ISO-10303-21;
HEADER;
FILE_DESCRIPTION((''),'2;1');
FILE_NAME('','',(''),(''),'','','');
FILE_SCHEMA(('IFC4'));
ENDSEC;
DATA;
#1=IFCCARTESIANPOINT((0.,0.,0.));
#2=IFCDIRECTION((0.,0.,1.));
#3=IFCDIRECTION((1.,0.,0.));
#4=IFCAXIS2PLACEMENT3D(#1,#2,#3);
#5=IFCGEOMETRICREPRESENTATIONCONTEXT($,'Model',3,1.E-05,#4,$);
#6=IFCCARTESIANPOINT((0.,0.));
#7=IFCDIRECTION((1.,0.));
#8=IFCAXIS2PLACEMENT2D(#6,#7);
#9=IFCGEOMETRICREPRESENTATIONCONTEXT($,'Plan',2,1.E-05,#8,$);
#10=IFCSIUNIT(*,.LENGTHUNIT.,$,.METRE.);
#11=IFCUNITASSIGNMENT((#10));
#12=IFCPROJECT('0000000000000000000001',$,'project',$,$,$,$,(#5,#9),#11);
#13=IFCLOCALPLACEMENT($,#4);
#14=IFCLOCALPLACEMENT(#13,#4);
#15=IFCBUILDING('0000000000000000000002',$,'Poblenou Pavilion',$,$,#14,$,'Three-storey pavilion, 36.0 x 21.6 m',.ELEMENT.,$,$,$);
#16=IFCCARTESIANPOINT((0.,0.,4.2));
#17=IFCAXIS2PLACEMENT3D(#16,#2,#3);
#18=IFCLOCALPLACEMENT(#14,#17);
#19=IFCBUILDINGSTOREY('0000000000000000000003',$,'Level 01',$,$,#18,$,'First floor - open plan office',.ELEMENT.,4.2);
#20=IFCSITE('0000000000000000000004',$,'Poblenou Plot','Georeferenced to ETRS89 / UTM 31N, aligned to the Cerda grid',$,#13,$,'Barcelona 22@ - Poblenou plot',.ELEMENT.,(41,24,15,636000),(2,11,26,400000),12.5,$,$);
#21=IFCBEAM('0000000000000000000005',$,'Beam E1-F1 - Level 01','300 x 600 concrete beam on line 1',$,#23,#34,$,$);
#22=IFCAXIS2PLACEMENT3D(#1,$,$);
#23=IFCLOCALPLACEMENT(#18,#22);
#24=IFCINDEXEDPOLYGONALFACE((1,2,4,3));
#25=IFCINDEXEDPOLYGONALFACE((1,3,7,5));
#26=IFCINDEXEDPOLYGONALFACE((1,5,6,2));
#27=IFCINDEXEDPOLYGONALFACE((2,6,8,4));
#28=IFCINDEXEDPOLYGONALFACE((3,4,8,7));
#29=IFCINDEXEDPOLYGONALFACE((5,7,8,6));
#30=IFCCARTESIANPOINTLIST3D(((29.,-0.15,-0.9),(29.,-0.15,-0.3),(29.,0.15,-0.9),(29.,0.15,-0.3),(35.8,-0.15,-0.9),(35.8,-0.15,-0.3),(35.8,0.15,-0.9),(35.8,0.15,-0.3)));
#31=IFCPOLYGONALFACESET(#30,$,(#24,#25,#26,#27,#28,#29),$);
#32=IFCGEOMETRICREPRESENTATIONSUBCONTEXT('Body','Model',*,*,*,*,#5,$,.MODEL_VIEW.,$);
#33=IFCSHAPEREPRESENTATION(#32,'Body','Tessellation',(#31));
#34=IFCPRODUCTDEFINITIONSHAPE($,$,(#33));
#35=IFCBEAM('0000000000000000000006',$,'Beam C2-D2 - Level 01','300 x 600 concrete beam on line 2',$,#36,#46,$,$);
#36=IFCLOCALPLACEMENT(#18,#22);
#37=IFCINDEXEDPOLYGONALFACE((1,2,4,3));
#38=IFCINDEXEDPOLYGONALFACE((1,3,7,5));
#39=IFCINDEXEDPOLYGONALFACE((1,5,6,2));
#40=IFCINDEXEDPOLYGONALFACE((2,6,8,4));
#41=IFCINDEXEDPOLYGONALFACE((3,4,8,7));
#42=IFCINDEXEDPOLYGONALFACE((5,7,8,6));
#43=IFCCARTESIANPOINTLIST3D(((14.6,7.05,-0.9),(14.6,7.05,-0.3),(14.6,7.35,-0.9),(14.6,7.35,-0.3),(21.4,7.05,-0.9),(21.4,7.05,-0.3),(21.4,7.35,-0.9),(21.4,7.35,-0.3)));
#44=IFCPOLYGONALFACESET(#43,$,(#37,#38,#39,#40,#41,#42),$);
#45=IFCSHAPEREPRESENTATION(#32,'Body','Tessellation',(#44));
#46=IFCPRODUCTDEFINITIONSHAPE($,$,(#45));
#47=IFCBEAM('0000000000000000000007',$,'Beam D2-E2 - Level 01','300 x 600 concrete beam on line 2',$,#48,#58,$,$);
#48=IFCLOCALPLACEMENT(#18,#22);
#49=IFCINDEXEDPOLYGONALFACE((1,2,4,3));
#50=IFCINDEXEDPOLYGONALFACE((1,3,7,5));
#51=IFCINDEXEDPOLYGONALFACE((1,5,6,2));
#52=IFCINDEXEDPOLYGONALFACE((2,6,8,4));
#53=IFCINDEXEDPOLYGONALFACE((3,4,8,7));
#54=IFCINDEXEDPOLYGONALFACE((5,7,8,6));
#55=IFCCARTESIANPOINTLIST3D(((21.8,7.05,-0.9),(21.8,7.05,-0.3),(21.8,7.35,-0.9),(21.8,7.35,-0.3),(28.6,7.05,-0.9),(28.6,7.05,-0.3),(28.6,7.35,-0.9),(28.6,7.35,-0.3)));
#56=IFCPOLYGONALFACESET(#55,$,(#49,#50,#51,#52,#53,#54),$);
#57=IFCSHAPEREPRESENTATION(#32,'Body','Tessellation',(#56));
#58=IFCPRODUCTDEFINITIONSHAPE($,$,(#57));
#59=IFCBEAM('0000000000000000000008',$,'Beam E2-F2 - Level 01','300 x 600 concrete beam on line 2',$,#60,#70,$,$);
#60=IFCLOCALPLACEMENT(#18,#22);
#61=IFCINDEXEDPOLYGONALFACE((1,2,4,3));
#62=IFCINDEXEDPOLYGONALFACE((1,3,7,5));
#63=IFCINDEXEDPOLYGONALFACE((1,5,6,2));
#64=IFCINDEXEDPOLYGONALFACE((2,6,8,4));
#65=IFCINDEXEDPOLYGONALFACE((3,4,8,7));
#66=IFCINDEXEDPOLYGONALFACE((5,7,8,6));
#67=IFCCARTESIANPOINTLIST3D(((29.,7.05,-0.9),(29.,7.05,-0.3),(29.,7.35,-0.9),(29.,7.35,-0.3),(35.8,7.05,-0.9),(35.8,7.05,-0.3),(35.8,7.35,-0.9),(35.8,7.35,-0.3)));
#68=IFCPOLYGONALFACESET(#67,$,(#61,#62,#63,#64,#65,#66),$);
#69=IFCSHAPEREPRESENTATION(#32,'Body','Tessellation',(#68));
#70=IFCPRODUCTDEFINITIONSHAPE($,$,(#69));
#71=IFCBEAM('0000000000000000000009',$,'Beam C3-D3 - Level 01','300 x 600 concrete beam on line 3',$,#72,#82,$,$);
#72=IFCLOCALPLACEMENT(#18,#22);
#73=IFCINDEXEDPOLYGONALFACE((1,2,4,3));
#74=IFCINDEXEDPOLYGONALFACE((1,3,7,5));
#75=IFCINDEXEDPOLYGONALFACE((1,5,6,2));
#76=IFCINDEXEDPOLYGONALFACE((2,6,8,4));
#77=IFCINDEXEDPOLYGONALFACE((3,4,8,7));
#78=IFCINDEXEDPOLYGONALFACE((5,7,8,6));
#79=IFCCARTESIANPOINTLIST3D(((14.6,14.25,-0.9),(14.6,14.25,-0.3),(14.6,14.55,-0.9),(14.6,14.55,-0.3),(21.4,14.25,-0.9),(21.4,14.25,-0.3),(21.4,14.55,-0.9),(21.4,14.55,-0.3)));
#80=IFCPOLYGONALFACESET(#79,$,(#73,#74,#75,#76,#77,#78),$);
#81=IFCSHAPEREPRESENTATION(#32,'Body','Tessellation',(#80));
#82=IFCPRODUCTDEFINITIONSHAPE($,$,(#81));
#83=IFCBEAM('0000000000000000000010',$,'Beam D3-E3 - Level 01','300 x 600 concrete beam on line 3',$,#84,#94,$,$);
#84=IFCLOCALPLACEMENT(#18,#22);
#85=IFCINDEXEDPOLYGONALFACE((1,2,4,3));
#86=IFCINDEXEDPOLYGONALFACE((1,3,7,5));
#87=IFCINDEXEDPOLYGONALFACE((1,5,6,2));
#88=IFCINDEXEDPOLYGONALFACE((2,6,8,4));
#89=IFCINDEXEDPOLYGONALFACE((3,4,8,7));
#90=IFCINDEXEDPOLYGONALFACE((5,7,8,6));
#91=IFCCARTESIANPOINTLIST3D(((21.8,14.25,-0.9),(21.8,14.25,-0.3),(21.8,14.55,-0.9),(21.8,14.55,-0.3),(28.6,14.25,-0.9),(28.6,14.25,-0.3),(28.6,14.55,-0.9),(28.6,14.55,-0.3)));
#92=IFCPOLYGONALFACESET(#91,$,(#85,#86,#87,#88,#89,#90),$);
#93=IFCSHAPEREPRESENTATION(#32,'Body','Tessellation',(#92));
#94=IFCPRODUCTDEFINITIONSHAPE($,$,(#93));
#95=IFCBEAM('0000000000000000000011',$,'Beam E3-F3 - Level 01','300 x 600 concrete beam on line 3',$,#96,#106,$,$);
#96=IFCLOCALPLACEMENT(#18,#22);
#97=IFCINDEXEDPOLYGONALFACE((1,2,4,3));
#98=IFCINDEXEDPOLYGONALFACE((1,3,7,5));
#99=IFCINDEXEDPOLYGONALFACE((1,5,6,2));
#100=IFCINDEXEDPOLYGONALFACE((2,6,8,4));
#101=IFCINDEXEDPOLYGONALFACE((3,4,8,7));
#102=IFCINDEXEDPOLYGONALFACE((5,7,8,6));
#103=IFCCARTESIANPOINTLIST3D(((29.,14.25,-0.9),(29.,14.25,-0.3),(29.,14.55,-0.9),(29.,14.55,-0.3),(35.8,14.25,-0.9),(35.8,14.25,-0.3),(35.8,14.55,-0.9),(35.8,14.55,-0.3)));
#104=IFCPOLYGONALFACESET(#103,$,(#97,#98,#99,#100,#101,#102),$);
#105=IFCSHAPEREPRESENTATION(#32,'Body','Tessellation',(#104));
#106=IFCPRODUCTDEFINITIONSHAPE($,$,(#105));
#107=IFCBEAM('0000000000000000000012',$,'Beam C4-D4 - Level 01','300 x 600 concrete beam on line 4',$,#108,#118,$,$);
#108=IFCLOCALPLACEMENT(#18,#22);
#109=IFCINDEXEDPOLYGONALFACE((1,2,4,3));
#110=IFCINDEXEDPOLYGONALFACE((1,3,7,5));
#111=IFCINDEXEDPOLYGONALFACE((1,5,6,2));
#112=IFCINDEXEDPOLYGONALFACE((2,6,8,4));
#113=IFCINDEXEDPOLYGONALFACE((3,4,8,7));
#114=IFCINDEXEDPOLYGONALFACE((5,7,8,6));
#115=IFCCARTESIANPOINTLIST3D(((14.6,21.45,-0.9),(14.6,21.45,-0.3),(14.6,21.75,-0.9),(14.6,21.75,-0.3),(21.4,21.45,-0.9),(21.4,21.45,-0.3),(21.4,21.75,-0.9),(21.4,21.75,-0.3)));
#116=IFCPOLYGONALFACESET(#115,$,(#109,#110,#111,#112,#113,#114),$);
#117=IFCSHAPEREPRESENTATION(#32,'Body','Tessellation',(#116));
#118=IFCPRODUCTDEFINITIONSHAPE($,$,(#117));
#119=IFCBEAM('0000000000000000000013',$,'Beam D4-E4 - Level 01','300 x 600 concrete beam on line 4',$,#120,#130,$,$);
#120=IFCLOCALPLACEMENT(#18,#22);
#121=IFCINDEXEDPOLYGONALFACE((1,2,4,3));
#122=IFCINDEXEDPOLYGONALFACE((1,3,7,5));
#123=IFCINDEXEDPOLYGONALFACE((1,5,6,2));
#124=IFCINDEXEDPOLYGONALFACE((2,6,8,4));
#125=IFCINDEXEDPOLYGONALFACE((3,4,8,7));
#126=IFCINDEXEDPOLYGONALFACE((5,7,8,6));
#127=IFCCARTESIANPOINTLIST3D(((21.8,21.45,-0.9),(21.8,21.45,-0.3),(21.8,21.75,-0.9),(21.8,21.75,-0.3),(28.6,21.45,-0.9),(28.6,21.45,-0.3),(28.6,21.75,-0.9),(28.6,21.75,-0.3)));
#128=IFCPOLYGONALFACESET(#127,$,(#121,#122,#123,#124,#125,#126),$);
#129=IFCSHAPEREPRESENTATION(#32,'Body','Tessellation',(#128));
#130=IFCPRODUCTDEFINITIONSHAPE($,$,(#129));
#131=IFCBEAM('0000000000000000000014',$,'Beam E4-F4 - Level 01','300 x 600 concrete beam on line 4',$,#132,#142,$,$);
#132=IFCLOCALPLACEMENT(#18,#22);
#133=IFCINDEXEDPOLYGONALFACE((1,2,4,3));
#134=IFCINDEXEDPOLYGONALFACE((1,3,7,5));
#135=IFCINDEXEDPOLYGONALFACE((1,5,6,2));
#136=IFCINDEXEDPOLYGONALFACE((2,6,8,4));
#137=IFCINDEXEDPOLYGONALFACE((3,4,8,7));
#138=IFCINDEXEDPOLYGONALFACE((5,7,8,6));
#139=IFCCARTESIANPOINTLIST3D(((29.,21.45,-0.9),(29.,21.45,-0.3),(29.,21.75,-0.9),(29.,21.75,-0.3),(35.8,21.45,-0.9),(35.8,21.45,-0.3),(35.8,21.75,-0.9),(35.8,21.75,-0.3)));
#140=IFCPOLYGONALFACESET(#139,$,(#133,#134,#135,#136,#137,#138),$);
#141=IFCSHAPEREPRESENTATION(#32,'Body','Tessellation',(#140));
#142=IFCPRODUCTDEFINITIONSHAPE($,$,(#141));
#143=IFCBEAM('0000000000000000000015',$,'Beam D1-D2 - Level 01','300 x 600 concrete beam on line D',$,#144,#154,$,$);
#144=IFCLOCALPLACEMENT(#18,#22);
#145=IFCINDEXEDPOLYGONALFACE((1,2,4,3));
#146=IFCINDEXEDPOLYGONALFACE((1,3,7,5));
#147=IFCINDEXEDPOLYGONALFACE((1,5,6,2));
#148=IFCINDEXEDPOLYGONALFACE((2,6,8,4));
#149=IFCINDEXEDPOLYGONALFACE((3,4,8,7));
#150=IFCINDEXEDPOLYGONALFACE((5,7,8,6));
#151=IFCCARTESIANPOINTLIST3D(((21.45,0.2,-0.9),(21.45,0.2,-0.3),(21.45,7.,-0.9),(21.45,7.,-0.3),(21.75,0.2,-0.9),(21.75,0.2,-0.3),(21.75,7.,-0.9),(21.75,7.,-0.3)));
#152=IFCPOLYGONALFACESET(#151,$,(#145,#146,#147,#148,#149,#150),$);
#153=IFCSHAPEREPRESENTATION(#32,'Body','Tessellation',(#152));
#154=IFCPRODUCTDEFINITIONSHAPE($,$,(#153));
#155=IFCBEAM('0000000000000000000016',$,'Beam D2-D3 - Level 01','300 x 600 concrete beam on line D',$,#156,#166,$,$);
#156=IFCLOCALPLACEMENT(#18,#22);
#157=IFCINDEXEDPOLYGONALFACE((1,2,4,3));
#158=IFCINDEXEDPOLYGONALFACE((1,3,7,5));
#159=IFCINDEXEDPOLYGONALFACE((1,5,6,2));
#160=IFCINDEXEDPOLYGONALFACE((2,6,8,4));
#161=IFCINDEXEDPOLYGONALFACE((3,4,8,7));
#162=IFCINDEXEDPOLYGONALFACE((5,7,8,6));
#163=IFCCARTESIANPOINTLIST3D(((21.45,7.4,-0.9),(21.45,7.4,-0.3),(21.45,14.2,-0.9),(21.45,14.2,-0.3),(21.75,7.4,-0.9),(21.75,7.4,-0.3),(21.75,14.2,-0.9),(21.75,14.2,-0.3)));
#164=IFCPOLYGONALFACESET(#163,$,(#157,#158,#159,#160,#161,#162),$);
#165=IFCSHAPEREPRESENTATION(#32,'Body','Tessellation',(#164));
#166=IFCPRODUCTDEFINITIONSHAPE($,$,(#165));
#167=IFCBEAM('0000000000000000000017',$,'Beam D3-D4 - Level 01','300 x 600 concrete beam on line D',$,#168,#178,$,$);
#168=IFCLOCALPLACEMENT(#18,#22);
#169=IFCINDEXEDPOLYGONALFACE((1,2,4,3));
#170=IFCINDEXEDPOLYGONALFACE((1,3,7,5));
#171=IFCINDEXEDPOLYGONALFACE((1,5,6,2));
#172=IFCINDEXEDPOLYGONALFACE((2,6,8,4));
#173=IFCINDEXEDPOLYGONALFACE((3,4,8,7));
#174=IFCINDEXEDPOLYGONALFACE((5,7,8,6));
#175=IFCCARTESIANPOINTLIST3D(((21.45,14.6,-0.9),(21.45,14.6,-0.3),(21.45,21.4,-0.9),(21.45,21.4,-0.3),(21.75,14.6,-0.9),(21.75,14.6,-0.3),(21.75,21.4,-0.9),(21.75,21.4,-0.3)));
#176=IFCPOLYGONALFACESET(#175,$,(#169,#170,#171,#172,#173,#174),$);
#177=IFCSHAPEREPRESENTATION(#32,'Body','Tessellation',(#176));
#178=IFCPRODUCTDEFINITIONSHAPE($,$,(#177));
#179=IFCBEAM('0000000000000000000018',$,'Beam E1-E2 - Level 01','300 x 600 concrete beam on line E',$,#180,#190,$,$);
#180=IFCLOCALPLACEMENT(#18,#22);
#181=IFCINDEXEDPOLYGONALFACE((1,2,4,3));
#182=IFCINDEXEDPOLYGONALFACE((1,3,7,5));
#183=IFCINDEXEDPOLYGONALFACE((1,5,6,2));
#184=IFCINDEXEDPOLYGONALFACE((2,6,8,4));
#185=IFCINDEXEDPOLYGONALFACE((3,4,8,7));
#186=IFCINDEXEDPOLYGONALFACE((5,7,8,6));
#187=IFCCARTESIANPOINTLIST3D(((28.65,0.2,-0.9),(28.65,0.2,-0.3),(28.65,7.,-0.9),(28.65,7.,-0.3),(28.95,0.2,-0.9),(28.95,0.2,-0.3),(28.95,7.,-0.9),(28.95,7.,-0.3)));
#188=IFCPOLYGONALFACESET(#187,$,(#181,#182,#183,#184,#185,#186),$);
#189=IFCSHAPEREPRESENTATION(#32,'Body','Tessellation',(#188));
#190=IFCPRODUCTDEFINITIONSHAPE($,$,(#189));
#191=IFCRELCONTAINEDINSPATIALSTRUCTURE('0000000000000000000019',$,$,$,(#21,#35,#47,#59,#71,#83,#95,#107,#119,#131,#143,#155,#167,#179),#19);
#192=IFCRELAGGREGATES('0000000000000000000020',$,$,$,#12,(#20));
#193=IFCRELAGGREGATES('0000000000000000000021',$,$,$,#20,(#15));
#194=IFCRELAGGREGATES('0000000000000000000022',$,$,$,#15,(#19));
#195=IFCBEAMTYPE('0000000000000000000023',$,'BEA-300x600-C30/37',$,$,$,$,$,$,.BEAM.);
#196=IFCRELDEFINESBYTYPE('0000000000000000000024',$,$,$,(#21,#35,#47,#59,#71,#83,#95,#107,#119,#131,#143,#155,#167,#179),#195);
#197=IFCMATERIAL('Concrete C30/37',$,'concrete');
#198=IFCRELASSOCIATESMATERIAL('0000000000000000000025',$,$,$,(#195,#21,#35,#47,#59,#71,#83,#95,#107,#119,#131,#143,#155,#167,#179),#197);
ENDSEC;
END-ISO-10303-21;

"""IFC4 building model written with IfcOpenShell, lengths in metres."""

from ifc_helpers import new_model, si_unit, frame, origin_with_axes, origin_2d_with_axis, place, context, subcontext, project, spatial, line, indexed_curve, rectangle, outline, extrude, material, material_profile, profile_set, profile_usage, type_object, element, save


model = new_model("IFC4")

# Units and contexts
model_context = context("Model", 3, precision=1e-05, world=origin_with_axes())
plan_context = context("Plan", 2, precision=1e-05, world=origin_2d_with_axis())
body_context = subcontext(model_context, "Body", "Model", "MODEL_VIEW")
ifc_project = project(units=[si_unit("LENGTHUNIT", "METRE")], contexts=[model_context, plan_context])

# Site, building, storey
site_placement = place(None, origin_with_axes())
site = spatial("IfcSite", under=ifc_project, at=site_placement, Name="Poblenou Plot", Description="Georeferenced to ETRS89 / UTM 31N, aligned to the Cerda grid", LongName="Barcelona 22@ - Poblenou plot", CompositionType="ELEMENT", RefLatitude=(41, 24, 15, 636000), RefLongitude=(2, 11, 26, 400000), RefElevation=12.5)
building_placement = place(site_placement, origin_with_axes())
building = spatial("IfcBuilding", under=site, at=building_placement, Name="Poblenou Pavilion", LongName="Three-storey pavilion, 36.0 x 21.6 m", CompositionType="ELEMENT")
storey_placement = place(building_placement, frame((0.0, 0.0, 4.2), z_axis=(0.0, 0.0, 1.0), x_axis=(1.0, 0.0, 0.0)))
storey = spatial("IfcBuildingStorey", under=building, at=storey_placement, Name="Level 01", LongName="First floor - open plan office", CompositionType="ELEMENT", Elevation=4.2)

# Shared definitions
ifc_material = material(Name="Concrete C30/37", Category="concrete")

# Beams
ifc_material_profile_1 = material_profile(ifc_material, rectangle(XDim=0.3, YDim=0.6))
ifc_profile_set_1 = profile_set([ifc_material_profile_1], Name="BEA-300x600-C30/37")
beam_type = type_object("IfcBeamType", Name="BEA-300x600-C30/37", PredefinedType="BEAM", material=ifc_profile_set_1)
ifc_profile_usage_1 = profile_usage(ifc_profile_set_1)
beam_1_placement = place(storey_placement, frame((29.0, -0.15, -0.9), z_axis=(1.0, 0.0, 0.0), x_axis=(0.0, 1.0, 0.0)))
element("IfcBeam", 1, at=beam_1_placement, inside=storey, type_object=beam_type, material=ifc_profile_usage_1, Name="Beam E1-F1 - Level 01", Description="300 x 600 concrete beam on line 1", context=body_context, shape_type="SweptSolid", body=[
    extrude(outline(indexed_curve([(0.0, 0.0), (0.3, 0.0), (0.3, 0.6), (0.0, 0.6)], segments=[line(1, 2, 3, 4, 1)])), origin_with_axes(), (0.0, 0.0, 1.0), 6.8),
])
ifc_profile_usage_2 = profile_usage(ifc_profile_set_1)
beam_2_placement = place(storey_placement, frame((14.6, 7.05, -0.9), z_axis=(1.0, 0.0, 0.0), x_axis=(0.0, 1.0, 0.0)))
element("IfcBeam", 2, at=beam_2_placement, inside=storey, type_object=beam_type, material=ifc_profile_usage_2, Name="Beam C2-D2 - Level 01", Description="300 x 600 concrete beam on line 2", context=body_context, shape_type="SweptSolid", body=[
    extrude(outline(indexed_curve([(0.0, 0.0), (0.3, 0.0), (0.3, 0.6), (0.0, 0.6)], segments=[line(1, 2, 3, 4, 1)])), origin_with_axes(), (0.0, 0.0, 1.0), 6.8),
])
ifc_profile_usage_3 = profile_usage(ifc_profile_set_1)
beam_3_placement = place(storey_placement, frame((21.8, 7.05, -0.9), z_axis=(1.0, 0.0, 0.0), x_axis=(0.0, 1.0, 0.0)))
element("IfcBeam", 3, at=beam_3_placement, inside=storey, type_object=beam_type, material=ifc_profile_usage_3, Name="Beam D2-E2 - Level 01", Description="300 x 600 concrete beam on line 2", context=body_context, shape_type="SweptSolid", body=[
    extrude(outline(indexed_curve([(0.0, 0.0), (0.3, 0.0), (0.3, 0.6), (0.0, 0.6)], segments=[line(1, 2, 3, 4, 1)])), origin_with_axes(), (0.0, 0.0, 1.0), 6.8),
])
ifc_profile_usage_4 = profile_usage(ifc_profile_set_1)
beam_4_placement = place(storey_placement, frame((29.0, 7.05, -0.9), z_axis=(1.0, 0.0, 0.0), x_axis=(0.0, 1.0, 0.0)))
element("IfcBeam", 4, at=beam_4_placement, inside=storey, type_object=beam_type, material=ifc_profile_usage_4, Name="Beam E2-F2 - Level 01", Description="300 x 600 concrete beam on line 2", context=body_context, shape_type="SweptSolid", body=[
    extrude(outline(indexed_curve([(0.0, 0.0), (0.3, 0.0), (0.3, 0.6), (0.0, 0.6)], segments=[line(1, 2, 3, 4, 1)])), origin_with_axes(), (0.0, 0.0, 1.0), 6.8),
])
ifc_profile_usage_5 = profile_usage(ifc_profile_set_1)
beam_5_placement = place(storey_placement, frame((14.6, 14.25, -0.9), z_axis=(1.0, 0.0, 0.0), x_axis=(0.0, 1.0, 0.0)))
element("IfcBeam", 5, at=beam_5_placement, inside=storey, type_object=beam_type, material=ifc_profile_usage_5, Name="Beam C3-D3 - Level 01", Description="300 x 600 concrete beam on line 3", context=body_context, shape_type="SweptSolid", body=[
    extrude(outline(indexed_curve([(0.0, 0.0), (0.3, 0.0), (0.3, 0.6), (0.0, 0.6)], segments=[line(1, 2, 3, 4, 1)])), origin_with_axes(), (0.0, 0.0, 1.0), 6.8),
])
ifc_profile_usage_6 = profile_usage(ifc_profile_set_1)
beam_6_placement = place(storey_placement, frame((21.8, 14.25, -0.9), z_axis=(1.0, 0.0, 0.0), x_axis=(0.0, 1.0, 0.0)))
element("IfcBeam", 6, at=beam_6_placement, inside=storey, type_object=beam_type, material=ifc_profile_usage_6, Name="Beam D3-E3 - Level 01", Description="300 x 600 concrete beam on line 3", context=body_context, shape_type="SweptSolid", body=[
    extrude(outline(indexed_curve([(0.0, 0.0), (0.3, 0.0), (0.3, 0.6), (0.0, 0.6)], segments=[line(1, 2, 3, 4, 1)])), origin_with_axes(), (0.0, 0.0, 1.0), 6.8),
])
ifc_profile_usage_7 = profile_usage(ifc_profile_set_1)
beam_7_placement = place(storey_placement, frame((29.0, 14.25, -0.9), z_axis=(1.0, 0.0, 0.0), x_axis=(0.0, 1.0, 0.0)))
element("IfcBeam", 7, at=beam_7_placement, inside=storey, type_object=beam_type, material=ifc_profile_usage_7, Name="Beam E3-F3 - Level 01", Description="300 x 600 concrete beam on line 3", context=body_context, shape_type="SweptSolid", body=[
    extrude(outline(indexed_curve([(0.0, 0.0), (0.3, 0.0), (0.3, 0.6), (0.0, 0.6)], segments=[line(1, 2, 3, 4, 1)])), origin_with_axes(), (0.0, 0.0, 1.0), 6.8),
])
ifc_profile_usage_8 = profile_usage(ifc_profile_set_1)
beam_8_placement = place(storey_placement, frame((14.6, 21.45, -0.9), z_axis=(1.0, 0.0, 0.0), x_axis=(0.0, 1.0, 0.0)))
element("IfcBeam", 8, at=beam_8_placement, inside=storey, type_object=beam_type, material=ifc_profile_usage_8, Name="Beam C4-D4 - Level 01", Description="300 x 600 concrete beam on line 4", context=body_context, shape_type="SweptSolid", body=[
    extrude(outline(indexed_curve([(0.0, 0.0), (0.3, 0.0), (0.3, 0.6), (0.0, 0.6)], segments=[line(1, 2, 3, 4, 1)])), origin_with_axes(), (0.0, 0.0, 1.0), 6.8),
])
ifc_profile_usage_9 = profile_usage(ifc_profile_set_1)
beam_9_placement = place(storey_placement, frame((21.8, 21.45, -0.9), z_axis=(1.0, 0.0, 0.0), x_axis=(0.0, 1.0, 0.0)))
element("IfcBeam", 9, at=beam_9_placement, inside=storey, type_object=beam_type, material=ifc_profile_usage_9, Name="Beam D4-E4 - Level 01", Description="300 x 600 concrete beam on line 4", context=body_context, shape_type="SweptSolid", body=[
    extrude(outline(indexed_curve([(0.0, 0.0), (0.3, 0.0), (0.3, 0.6), (0.0, 0.6)], segments=[line(1, 2, 3, 4, 1)])), origin_with_axes(), (0.0, 0.0, 1.0), 6.8),
])
ifc_profile_usage_10 = profile_usage(ifc_profile_set_1)
beam_10_placement = place(storey_placement, frame((29.0, 21.45, -0.9), z_axis=(1.0, 0.0, 0.0), x_axis=(0.0, 1.0, 0.0)))
element("IfcBeam", 10, at=beam_10_placement, inside=storey, type_object=beam_type, material=ifc_profile_usage_10, Name="Beam E4-F4 - Level 01", Description="300 x 600 concrete beam on line 4", context=body_context, shape_type="SweptSolid", body=[
    extrude(outline(indexed_curve([(0.0, 0.0), (0.3, 0.0), (0.3, 0.6), (0.0, 0.6)], segments=[line(1, 2, 3, 4, 1)])), origin_with_axes(), (0.0, 0.0, 1.0), 6.8),
])
ifc_profile_usage_11 = profile_usage(ifc_profile_set_1)
beam_11_placement = place(storey_placement, frame((21.45, 0.2, -0.9), z_axis=(0.0, 1.0, 0.0), x_axis=(0.0, 0.0, 1.0)))
element("IfcBeam", 11, at=beam_11_placement, inside=storey, type_object=beam_type, material=ifc_profile_usage_11, Name="Beam D1-D2 - Level 01", Description="300 x 600 concrete beam on line D", context=body_context, shape_type="SweptSolid", body=[
    extrude(outline(indexed_curve([(0.0, 0.0), (0.6, 0.0), (0.6, 0.3), (0.0, 0.3)], segments=[line(1, 2, 3, 4, 1)])), origin_with_axes(), (0.0, 0.0, 1.0), 6.8),
])
ifc_profile_usage_12 = profile_usage(ifc_profile_set_1)
beam_12_placement = place(storey_placement, frame((21.45, 7.4, -0.9), z_axis=(0.0, 1.0, 0.0), x_axis=(0.0, 0.0, 1.0)))
element("IfcBeam", 12, at=beam_12_placement, inside=storey, type_object=beam_type, material=ifc_profile_usage_12, Name="Beam D2-D3 - Level 01", Description="300 x 600 concrete beam on line D", context=body_context, shape_type="SweptSolid", body=[
    extrude(outline(indexed_curve([(0.0, 0.0), (0.6, 0.0), (0.6, 0.3), (0.0, 0.3)], segments=[line(1, 2, 3, 4, 1)])), origin_with_axes(), (0.0, 0.0, 1.0), 6.8),
])
ifc_profile_usage_13 = profile_usage(ifc_profile_set_1)
beam_13_placement = place(storey_placement, frame((21.45, 14.6, -0.9), z_axis=(0.0, 1.0, 0.0), x_axis=(0.0, 0.0, 1.0)))
element("IfcBeam", 13, at=beam_13_placement, inside=storey, type_object=beam_type, material=ifc_profile_usage_13, Name="Beam D3-D4 - Level 01", Description="300 x 600 concrete beam on line D", context=body_context, shape_type="SweptSolid", body=[
    extrude(outline(indexed_curve([(0.0, 0.0), (0.6, 0.0), (0.6, 0.3), (0.0, 0.3)], segments=[line(1, 2, 3, 4, 1)])), origin_with_axes(), (0.0, 0.0, 1.0), 6.8),
])
ifc_profile_usage_14 = profile_usage(ifc_profile_set_1)
beam_14_placement = place(storey_placement, frame((28.65, 0.2, -0.9), z_axis=(0.0, 1.0, 0.0), x_axis=(0.0, 0.0, 1.0)))
element("IfcBeam", 14, at=beam_14_placement, inside=storey, type_object=beam_type, material=ifc_profile_usage_14, Name="Beam E1-E2 - Level 01", Description="300 x 600 concrete beam on line E", context=body_context, shape_type="SweptSolid", body=[
    extrude(outline(indexed_curve([(0.0, 0.0), (0.6, 0.0), (0.6, 0.3), (0.0, 0.3)], segments=[line(1, 2, 3, 4, 1)])), origin_with_axes(), (0.0, 0.0, 1.0), 6.8),
])

save(model, "model.ifc")
